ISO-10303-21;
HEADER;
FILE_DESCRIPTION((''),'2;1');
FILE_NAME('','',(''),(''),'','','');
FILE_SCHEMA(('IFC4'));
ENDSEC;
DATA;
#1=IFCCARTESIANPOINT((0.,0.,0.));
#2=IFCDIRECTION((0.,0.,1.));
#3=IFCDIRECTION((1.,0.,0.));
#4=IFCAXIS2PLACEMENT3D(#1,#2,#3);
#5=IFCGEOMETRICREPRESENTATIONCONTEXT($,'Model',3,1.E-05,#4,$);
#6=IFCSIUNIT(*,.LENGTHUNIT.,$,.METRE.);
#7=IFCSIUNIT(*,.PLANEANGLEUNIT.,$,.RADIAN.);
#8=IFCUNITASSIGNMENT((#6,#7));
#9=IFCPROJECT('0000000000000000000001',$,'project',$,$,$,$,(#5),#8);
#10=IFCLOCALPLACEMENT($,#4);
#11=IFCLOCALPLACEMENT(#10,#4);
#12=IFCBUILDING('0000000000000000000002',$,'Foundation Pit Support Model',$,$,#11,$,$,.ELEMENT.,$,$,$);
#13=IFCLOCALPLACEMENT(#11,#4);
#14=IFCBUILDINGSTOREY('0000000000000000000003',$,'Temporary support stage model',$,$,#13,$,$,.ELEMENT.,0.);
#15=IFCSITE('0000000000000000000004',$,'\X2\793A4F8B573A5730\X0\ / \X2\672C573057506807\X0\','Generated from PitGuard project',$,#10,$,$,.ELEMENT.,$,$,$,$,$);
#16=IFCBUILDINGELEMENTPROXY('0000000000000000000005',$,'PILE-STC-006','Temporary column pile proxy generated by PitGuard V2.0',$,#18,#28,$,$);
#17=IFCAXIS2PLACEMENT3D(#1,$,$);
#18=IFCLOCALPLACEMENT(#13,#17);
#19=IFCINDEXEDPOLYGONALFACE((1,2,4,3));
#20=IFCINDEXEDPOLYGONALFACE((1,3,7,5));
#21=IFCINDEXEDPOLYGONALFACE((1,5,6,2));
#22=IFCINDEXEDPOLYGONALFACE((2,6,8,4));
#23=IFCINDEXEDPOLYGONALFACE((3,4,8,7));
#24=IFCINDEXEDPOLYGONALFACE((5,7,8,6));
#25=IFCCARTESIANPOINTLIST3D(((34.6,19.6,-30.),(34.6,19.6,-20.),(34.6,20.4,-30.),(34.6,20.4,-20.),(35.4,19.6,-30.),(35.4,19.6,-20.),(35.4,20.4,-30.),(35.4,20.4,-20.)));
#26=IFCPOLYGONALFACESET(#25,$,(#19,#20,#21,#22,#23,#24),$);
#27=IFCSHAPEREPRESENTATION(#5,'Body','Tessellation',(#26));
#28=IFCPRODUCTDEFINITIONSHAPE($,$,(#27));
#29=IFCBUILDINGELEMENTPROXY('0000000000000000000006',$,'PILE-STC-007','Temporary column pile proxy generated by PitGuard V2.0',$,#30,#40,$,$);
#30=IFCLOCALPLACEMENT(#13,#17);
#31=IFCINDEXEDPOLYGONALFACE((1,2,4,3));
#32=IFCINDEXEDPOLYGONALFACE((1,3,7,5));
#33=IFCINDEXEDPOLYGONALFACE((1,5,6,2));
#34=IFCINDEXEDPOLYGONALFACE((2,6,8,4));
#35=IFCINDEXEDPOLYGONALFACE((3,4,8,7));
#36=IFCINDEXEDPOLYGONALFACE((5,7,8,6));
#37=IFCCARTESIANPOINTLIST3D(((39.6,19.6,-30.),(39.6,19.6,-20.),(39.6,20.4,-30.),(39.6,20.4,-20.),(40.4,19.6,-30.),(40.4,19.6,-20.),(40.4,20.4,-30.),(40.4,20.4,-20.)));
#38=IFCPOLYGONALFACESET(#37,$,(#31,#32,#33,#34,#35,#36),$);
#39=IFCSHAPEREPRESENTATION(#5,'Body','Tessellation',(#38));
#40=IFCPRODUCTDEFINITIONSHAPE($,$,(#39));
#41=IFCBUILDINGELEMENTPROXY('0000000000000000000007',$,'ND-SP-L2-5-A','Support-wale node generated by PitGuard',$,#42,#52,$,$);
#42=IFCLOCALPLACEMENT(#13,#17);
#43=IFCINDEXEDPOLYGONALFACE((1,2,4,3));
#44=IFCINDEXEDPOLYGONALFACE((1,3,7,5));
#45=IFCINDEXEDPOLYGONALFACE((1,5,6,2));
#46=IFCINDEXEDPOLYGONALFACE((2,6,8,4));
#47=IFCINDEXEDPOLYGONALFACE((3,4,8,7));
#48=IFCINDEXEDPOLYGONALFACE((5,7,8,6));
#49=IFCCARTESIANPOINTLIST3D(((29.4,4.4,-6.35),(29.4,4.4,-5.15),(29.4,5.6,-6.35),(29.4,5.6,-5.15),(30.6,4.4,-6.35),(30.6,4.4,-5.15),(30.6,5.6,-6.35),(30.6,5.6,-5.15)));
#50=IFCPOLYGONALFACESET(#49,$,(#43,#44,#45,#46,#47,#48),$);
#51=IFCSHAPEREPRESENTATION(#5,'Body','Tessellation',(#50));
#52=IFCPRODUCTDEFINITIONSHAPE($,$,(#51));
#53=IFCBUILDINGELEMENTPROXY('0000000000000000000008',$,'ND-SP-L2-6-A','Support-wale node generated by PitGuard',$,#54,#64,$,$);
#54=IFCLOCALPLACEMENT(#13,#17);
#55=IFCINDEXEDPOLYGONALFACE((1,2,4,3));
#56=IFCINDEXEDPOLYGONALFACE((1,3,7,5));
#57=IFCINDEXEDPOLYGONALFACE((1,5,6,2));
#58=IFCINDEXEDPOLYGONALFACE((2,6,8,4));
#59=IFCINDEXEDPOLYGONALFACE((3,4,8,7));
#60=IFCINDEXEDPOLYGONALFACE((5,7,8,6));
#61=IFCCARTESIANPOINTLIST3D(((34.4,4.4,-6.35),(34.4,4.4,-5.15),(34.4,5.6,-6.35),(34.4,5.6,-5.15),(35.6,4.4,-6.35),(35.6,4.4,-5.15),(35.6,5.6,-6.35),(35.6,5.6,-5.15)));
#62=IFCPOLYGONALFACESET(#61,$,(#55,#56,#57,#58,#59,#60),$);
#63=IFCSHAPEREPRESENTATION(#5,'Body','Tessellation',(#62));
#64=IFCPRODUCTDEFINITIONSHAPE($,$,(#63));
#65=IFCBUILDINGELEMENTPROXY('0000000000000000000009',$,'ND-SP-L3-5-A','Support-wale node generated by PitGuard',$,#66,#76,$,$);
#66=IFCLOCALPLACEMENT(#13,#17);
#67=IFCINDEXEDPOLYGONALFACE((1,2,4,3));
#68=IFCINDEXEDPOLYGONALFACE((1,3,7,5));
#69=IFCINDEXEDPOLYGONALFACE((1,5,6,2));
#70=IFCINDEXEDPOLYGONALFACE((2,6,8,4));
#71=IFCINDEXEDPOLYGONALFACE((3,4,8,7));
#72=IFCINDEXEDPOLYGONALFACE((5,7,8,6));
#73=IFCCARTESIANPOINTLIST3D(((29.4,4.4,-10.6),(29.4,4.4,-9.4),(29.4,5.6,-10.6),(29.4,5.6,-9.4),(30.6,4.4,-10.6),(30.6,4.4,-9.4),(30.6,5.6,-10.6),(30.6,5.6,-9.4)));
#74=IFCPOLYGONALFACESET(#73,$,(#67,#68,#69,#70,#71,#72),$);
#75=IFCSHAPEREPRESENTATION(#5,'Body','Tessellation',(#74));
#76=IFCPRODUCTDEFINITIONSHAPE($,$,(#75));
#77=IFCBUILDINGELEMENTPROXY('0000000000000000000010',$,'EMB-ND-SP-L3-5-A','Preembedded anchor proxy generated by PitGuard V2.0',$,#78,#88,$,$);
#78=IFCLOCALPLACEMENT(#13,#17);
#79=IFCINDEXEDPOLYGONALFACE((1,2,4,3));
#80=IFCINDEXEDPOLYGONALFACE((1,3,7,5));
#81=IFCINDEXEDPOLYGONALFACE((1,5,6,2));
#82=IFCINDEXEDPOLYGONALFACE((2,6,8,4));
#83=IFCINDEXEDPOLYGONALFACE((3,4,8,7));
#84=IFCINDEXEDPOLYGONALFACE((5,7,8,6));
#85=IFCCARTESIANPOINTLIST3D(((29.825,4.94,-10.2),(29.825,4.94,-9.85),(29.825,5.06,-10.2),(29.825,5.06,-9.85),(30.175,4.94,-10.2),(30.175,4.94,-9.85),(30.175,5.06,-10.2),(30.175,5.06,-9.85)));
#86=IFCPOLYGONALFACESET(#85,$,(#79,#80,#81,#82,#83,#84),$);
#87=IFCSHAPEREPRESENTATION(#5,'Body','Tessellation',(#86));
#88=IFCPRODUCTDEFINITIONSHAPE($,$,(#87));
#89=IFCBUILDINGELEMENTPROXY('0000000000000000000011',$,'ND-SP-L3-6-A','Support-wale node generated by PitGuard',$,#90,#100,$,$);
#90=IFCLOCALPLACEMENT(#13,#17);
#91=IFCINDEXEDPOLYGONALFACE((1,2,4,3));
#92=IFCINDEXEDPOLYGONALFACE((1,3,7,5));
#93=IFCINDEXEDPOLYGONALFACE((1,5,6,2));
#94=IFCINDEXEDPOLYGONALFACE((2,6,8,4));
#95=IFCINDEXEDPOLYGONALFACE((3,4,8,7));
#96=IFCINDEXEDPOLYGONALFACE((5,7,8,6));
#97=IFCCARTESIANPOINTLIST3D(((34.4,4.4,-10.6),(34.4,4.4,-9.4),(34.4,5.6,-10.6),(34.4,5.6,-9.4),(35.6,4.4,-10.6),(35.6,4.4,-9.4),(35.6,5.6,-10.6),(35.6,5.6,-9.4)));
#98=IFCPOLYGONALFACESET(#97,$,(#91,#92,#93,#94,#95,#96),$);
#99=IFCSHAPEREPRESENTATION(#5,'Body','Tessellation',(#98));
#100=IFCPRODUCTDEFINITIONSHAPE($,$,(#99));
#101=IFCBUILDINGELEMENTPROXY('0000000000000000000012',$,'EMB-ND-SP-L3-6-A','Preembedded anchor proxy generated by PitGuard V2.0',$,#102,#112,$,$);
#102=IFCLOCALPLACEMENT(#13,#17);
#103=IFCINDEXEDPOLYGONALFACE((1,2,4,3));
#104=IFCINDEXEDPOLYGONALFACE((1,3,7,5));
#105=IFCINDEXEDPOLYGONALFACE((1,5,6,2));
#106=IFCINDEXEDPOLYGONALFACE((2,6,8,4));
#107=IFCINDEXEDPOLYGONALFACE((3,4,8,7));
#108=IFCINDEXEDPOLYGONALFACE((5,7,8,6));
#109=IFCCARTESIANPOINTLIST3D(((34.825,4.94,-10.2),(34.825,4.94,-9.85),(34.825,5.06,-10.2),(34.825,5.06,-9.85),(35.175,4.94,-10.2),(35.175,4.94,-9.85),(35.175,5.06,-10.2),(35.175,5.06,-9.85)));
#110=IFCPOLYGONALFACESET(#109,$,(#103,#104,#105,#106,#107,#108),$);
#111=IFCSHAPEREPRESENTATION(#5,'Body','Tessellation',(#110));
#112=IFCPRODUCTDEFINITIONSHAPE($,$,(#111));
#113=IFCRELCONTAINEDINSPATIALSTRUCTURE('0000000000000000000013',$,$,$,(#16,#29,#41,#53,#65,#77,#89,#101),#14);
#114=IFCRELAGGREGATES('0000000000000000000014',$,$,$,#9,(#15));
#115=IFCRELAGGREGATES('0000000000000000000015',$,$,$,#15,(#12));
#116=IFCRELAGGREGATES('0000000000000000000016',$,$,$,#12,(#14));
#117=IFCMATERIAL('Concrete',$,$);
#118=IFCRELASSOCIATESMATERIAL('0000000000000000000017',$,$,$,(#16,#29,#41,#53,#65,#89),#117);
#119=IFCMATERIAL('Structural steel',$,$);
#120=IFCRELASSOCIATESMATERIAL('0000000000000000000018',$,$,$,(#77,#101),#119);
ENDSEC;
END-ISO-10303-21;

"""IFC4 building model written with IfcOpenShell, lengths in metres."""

from ifc_helpers import new_model, si_unit, frame, origin_with_axes, origin_2d, place, context, project, spatial, rectangle, extrude, material, element, save


model = new_model("IFC4")

# Units and contexts
model_context = context("Model", 3, precision=1e-05, world=origin_with_axes())
ifc_project = project(units=[si_unit("LENGTHUNIT", "METRE"), si_unit("PLANEANGLEUNIT", "RADIAN")], contexts=[model_context])

# Site, building, storey
site_placement = place(None, origin_with_axes())
site = spatial("IfcSite", under=ifc_project, at=site_placement, Name="示例场地 / 本地坐标", Description="Generated from PitGuard project", CompositionType="ELEMENT")
building_placement = place(site_placement, origin_with_axes())
building = spatial("IfcBuilding", under=site, at=building_placement, Name="Foundation Pit Support Model", CompositionType="ELEMENT")
storey_placement = place(building_placement, origin_with_axes())
storey = spatial("IfcBuildingStorey", under=building, at=storey_placement, Name="Temporary support stage model", CompositionType="ELEMENT", Elevation=0.0)

# Shared definitions
ifc_material_1 = material(Name="Structural steel")

# Shared definitions
ifc_material_2 = material(Name="Concrete")

# Building element proxies
for number, where, z_axis, x_axis, name in (
    (1, (35.0, 20.0, -30.0), (0.0, 0.0, 1.0), (1.0, 0.0, 0.0), "PILE-STC-006"),
    (2, (40.0, 20.0, -30.0), (0.0, 0.0, 1.0), (1.0, 0.0, 0.0), "PILE-STC-007"),
):
    element("IfcBuildingElementProxy", number, at=place(storey_placement, frame(where, z_axis=z_axis, x_axis=x_axis)), inside=storey, material=ifc_material_2, Name=name, Description="Temporary column pile proxy generated by PitGuard V2.0", context=model_context, shape_type="SweptSolid", body=[
        extrude(rectangle(XDim=0.8, YDim=0.8, at=origin_2d()), origin_with_axes(), (0.0, 0.0, 1.0), 10.0),
    ])
for number, where, z_axis, x_axis, name in (
    (3, (30.0, 5.0, -6.35), (0.0, 0.0, 1.0), (1.0, 0.0, 0.0), "ND-SP-L2-5-A"),
    (4, (35.0, 5.0, -6.35), (0.0, 0.0, 1.0), (1.0, 0.0, 0.0), "ND-SP-L2-6-A"),
    (5, (30.0, 5.0, -10.6), (0.0, 0.0, 1.0), (1.0, 0.0, 0.0), "ND-SP-L3-5-A"),
):
    element("IfcBuildingElementProxy", number, at=place(storey_placement, frame(where, z_axis=z_axis, x_axis=x_axis)), inside=storey, material=ifc_material_2, Name=name, Description="Support-wale node generated by PitGuard", context=model_context, shape_type="SweptSolid", body=[
        extrude(rectangle(XDim=1.2, YDim=1.2, at=origin_2d()), origin_with_axes(), (0.0, 0.0, 1.0), 1.2),
    ])
proxy_1_placement = place(storey_placement, frame((30.0, 5.0, -10.2), z_axis=(0.0, 0.0, 1.0), x_axis=(1.0, 0.0, 0.0)))
element("IfcBuildingElementProxy", 6, at=proxy_1_placement, inside=storey, material=ifc_material_1, Name="EMB-ND-SP-L3-5-A", Description="Preembedded anchor proxy generated by PitGuard V2.0", context=model_context, shape_type="SweptSolid", body=[
    extrude(rectangle(XDim=0.35, YDim=0.12, at=origin_2d()), origin_with_axes(), (0.0, 0.0, 1.0), 0.35),
])
proxy_2_placement = place(storey_placement, frame((35.0, 5.0, -10.6), z_axis=(0.0, 0.0, 1.0), x_axis=(1.0, 0.0, 0.0)))
element("IfcBuildingElementProxy", 7, at=proxy_2_placement, inside=storey, material=ifc_material_2, Name="ND-SP-L3-6-A", Description="Support-wale node generated by PitGuard", context=model_context, shape_type="SweptSolid", body=[
    extrude(rectangle(XDim=1.2, YDim=1.2, at=origin_2d()), origin_with_axes(), (0.0, 0.0, 1.0), 1.2),
])
proxy_3_placement = place(storey_placement, frame((35.0, 5.0, -10.2), z_axis=(0.0, 0.0, 1.0), x_axis=(1.0, 0.0, 0.0)))
element("IfcBuildingElementProxy", 8, at=proxy_3_placement, inside=storey, material=ifc_material_1, Name="EMB-ND-SP-L3-6-A", Description="Preembedded anchor proxy generated by PitGuard V2.0", context=model_context, shape_type="SweptSolid", body=[
    extrude(rectangle(XDim=0.35, YDim=0.12, at=origin_2d()), origin_with_axes(), (0.0, 0.0, 1.0), 0.35),
])

save(model, "model.ifc")
